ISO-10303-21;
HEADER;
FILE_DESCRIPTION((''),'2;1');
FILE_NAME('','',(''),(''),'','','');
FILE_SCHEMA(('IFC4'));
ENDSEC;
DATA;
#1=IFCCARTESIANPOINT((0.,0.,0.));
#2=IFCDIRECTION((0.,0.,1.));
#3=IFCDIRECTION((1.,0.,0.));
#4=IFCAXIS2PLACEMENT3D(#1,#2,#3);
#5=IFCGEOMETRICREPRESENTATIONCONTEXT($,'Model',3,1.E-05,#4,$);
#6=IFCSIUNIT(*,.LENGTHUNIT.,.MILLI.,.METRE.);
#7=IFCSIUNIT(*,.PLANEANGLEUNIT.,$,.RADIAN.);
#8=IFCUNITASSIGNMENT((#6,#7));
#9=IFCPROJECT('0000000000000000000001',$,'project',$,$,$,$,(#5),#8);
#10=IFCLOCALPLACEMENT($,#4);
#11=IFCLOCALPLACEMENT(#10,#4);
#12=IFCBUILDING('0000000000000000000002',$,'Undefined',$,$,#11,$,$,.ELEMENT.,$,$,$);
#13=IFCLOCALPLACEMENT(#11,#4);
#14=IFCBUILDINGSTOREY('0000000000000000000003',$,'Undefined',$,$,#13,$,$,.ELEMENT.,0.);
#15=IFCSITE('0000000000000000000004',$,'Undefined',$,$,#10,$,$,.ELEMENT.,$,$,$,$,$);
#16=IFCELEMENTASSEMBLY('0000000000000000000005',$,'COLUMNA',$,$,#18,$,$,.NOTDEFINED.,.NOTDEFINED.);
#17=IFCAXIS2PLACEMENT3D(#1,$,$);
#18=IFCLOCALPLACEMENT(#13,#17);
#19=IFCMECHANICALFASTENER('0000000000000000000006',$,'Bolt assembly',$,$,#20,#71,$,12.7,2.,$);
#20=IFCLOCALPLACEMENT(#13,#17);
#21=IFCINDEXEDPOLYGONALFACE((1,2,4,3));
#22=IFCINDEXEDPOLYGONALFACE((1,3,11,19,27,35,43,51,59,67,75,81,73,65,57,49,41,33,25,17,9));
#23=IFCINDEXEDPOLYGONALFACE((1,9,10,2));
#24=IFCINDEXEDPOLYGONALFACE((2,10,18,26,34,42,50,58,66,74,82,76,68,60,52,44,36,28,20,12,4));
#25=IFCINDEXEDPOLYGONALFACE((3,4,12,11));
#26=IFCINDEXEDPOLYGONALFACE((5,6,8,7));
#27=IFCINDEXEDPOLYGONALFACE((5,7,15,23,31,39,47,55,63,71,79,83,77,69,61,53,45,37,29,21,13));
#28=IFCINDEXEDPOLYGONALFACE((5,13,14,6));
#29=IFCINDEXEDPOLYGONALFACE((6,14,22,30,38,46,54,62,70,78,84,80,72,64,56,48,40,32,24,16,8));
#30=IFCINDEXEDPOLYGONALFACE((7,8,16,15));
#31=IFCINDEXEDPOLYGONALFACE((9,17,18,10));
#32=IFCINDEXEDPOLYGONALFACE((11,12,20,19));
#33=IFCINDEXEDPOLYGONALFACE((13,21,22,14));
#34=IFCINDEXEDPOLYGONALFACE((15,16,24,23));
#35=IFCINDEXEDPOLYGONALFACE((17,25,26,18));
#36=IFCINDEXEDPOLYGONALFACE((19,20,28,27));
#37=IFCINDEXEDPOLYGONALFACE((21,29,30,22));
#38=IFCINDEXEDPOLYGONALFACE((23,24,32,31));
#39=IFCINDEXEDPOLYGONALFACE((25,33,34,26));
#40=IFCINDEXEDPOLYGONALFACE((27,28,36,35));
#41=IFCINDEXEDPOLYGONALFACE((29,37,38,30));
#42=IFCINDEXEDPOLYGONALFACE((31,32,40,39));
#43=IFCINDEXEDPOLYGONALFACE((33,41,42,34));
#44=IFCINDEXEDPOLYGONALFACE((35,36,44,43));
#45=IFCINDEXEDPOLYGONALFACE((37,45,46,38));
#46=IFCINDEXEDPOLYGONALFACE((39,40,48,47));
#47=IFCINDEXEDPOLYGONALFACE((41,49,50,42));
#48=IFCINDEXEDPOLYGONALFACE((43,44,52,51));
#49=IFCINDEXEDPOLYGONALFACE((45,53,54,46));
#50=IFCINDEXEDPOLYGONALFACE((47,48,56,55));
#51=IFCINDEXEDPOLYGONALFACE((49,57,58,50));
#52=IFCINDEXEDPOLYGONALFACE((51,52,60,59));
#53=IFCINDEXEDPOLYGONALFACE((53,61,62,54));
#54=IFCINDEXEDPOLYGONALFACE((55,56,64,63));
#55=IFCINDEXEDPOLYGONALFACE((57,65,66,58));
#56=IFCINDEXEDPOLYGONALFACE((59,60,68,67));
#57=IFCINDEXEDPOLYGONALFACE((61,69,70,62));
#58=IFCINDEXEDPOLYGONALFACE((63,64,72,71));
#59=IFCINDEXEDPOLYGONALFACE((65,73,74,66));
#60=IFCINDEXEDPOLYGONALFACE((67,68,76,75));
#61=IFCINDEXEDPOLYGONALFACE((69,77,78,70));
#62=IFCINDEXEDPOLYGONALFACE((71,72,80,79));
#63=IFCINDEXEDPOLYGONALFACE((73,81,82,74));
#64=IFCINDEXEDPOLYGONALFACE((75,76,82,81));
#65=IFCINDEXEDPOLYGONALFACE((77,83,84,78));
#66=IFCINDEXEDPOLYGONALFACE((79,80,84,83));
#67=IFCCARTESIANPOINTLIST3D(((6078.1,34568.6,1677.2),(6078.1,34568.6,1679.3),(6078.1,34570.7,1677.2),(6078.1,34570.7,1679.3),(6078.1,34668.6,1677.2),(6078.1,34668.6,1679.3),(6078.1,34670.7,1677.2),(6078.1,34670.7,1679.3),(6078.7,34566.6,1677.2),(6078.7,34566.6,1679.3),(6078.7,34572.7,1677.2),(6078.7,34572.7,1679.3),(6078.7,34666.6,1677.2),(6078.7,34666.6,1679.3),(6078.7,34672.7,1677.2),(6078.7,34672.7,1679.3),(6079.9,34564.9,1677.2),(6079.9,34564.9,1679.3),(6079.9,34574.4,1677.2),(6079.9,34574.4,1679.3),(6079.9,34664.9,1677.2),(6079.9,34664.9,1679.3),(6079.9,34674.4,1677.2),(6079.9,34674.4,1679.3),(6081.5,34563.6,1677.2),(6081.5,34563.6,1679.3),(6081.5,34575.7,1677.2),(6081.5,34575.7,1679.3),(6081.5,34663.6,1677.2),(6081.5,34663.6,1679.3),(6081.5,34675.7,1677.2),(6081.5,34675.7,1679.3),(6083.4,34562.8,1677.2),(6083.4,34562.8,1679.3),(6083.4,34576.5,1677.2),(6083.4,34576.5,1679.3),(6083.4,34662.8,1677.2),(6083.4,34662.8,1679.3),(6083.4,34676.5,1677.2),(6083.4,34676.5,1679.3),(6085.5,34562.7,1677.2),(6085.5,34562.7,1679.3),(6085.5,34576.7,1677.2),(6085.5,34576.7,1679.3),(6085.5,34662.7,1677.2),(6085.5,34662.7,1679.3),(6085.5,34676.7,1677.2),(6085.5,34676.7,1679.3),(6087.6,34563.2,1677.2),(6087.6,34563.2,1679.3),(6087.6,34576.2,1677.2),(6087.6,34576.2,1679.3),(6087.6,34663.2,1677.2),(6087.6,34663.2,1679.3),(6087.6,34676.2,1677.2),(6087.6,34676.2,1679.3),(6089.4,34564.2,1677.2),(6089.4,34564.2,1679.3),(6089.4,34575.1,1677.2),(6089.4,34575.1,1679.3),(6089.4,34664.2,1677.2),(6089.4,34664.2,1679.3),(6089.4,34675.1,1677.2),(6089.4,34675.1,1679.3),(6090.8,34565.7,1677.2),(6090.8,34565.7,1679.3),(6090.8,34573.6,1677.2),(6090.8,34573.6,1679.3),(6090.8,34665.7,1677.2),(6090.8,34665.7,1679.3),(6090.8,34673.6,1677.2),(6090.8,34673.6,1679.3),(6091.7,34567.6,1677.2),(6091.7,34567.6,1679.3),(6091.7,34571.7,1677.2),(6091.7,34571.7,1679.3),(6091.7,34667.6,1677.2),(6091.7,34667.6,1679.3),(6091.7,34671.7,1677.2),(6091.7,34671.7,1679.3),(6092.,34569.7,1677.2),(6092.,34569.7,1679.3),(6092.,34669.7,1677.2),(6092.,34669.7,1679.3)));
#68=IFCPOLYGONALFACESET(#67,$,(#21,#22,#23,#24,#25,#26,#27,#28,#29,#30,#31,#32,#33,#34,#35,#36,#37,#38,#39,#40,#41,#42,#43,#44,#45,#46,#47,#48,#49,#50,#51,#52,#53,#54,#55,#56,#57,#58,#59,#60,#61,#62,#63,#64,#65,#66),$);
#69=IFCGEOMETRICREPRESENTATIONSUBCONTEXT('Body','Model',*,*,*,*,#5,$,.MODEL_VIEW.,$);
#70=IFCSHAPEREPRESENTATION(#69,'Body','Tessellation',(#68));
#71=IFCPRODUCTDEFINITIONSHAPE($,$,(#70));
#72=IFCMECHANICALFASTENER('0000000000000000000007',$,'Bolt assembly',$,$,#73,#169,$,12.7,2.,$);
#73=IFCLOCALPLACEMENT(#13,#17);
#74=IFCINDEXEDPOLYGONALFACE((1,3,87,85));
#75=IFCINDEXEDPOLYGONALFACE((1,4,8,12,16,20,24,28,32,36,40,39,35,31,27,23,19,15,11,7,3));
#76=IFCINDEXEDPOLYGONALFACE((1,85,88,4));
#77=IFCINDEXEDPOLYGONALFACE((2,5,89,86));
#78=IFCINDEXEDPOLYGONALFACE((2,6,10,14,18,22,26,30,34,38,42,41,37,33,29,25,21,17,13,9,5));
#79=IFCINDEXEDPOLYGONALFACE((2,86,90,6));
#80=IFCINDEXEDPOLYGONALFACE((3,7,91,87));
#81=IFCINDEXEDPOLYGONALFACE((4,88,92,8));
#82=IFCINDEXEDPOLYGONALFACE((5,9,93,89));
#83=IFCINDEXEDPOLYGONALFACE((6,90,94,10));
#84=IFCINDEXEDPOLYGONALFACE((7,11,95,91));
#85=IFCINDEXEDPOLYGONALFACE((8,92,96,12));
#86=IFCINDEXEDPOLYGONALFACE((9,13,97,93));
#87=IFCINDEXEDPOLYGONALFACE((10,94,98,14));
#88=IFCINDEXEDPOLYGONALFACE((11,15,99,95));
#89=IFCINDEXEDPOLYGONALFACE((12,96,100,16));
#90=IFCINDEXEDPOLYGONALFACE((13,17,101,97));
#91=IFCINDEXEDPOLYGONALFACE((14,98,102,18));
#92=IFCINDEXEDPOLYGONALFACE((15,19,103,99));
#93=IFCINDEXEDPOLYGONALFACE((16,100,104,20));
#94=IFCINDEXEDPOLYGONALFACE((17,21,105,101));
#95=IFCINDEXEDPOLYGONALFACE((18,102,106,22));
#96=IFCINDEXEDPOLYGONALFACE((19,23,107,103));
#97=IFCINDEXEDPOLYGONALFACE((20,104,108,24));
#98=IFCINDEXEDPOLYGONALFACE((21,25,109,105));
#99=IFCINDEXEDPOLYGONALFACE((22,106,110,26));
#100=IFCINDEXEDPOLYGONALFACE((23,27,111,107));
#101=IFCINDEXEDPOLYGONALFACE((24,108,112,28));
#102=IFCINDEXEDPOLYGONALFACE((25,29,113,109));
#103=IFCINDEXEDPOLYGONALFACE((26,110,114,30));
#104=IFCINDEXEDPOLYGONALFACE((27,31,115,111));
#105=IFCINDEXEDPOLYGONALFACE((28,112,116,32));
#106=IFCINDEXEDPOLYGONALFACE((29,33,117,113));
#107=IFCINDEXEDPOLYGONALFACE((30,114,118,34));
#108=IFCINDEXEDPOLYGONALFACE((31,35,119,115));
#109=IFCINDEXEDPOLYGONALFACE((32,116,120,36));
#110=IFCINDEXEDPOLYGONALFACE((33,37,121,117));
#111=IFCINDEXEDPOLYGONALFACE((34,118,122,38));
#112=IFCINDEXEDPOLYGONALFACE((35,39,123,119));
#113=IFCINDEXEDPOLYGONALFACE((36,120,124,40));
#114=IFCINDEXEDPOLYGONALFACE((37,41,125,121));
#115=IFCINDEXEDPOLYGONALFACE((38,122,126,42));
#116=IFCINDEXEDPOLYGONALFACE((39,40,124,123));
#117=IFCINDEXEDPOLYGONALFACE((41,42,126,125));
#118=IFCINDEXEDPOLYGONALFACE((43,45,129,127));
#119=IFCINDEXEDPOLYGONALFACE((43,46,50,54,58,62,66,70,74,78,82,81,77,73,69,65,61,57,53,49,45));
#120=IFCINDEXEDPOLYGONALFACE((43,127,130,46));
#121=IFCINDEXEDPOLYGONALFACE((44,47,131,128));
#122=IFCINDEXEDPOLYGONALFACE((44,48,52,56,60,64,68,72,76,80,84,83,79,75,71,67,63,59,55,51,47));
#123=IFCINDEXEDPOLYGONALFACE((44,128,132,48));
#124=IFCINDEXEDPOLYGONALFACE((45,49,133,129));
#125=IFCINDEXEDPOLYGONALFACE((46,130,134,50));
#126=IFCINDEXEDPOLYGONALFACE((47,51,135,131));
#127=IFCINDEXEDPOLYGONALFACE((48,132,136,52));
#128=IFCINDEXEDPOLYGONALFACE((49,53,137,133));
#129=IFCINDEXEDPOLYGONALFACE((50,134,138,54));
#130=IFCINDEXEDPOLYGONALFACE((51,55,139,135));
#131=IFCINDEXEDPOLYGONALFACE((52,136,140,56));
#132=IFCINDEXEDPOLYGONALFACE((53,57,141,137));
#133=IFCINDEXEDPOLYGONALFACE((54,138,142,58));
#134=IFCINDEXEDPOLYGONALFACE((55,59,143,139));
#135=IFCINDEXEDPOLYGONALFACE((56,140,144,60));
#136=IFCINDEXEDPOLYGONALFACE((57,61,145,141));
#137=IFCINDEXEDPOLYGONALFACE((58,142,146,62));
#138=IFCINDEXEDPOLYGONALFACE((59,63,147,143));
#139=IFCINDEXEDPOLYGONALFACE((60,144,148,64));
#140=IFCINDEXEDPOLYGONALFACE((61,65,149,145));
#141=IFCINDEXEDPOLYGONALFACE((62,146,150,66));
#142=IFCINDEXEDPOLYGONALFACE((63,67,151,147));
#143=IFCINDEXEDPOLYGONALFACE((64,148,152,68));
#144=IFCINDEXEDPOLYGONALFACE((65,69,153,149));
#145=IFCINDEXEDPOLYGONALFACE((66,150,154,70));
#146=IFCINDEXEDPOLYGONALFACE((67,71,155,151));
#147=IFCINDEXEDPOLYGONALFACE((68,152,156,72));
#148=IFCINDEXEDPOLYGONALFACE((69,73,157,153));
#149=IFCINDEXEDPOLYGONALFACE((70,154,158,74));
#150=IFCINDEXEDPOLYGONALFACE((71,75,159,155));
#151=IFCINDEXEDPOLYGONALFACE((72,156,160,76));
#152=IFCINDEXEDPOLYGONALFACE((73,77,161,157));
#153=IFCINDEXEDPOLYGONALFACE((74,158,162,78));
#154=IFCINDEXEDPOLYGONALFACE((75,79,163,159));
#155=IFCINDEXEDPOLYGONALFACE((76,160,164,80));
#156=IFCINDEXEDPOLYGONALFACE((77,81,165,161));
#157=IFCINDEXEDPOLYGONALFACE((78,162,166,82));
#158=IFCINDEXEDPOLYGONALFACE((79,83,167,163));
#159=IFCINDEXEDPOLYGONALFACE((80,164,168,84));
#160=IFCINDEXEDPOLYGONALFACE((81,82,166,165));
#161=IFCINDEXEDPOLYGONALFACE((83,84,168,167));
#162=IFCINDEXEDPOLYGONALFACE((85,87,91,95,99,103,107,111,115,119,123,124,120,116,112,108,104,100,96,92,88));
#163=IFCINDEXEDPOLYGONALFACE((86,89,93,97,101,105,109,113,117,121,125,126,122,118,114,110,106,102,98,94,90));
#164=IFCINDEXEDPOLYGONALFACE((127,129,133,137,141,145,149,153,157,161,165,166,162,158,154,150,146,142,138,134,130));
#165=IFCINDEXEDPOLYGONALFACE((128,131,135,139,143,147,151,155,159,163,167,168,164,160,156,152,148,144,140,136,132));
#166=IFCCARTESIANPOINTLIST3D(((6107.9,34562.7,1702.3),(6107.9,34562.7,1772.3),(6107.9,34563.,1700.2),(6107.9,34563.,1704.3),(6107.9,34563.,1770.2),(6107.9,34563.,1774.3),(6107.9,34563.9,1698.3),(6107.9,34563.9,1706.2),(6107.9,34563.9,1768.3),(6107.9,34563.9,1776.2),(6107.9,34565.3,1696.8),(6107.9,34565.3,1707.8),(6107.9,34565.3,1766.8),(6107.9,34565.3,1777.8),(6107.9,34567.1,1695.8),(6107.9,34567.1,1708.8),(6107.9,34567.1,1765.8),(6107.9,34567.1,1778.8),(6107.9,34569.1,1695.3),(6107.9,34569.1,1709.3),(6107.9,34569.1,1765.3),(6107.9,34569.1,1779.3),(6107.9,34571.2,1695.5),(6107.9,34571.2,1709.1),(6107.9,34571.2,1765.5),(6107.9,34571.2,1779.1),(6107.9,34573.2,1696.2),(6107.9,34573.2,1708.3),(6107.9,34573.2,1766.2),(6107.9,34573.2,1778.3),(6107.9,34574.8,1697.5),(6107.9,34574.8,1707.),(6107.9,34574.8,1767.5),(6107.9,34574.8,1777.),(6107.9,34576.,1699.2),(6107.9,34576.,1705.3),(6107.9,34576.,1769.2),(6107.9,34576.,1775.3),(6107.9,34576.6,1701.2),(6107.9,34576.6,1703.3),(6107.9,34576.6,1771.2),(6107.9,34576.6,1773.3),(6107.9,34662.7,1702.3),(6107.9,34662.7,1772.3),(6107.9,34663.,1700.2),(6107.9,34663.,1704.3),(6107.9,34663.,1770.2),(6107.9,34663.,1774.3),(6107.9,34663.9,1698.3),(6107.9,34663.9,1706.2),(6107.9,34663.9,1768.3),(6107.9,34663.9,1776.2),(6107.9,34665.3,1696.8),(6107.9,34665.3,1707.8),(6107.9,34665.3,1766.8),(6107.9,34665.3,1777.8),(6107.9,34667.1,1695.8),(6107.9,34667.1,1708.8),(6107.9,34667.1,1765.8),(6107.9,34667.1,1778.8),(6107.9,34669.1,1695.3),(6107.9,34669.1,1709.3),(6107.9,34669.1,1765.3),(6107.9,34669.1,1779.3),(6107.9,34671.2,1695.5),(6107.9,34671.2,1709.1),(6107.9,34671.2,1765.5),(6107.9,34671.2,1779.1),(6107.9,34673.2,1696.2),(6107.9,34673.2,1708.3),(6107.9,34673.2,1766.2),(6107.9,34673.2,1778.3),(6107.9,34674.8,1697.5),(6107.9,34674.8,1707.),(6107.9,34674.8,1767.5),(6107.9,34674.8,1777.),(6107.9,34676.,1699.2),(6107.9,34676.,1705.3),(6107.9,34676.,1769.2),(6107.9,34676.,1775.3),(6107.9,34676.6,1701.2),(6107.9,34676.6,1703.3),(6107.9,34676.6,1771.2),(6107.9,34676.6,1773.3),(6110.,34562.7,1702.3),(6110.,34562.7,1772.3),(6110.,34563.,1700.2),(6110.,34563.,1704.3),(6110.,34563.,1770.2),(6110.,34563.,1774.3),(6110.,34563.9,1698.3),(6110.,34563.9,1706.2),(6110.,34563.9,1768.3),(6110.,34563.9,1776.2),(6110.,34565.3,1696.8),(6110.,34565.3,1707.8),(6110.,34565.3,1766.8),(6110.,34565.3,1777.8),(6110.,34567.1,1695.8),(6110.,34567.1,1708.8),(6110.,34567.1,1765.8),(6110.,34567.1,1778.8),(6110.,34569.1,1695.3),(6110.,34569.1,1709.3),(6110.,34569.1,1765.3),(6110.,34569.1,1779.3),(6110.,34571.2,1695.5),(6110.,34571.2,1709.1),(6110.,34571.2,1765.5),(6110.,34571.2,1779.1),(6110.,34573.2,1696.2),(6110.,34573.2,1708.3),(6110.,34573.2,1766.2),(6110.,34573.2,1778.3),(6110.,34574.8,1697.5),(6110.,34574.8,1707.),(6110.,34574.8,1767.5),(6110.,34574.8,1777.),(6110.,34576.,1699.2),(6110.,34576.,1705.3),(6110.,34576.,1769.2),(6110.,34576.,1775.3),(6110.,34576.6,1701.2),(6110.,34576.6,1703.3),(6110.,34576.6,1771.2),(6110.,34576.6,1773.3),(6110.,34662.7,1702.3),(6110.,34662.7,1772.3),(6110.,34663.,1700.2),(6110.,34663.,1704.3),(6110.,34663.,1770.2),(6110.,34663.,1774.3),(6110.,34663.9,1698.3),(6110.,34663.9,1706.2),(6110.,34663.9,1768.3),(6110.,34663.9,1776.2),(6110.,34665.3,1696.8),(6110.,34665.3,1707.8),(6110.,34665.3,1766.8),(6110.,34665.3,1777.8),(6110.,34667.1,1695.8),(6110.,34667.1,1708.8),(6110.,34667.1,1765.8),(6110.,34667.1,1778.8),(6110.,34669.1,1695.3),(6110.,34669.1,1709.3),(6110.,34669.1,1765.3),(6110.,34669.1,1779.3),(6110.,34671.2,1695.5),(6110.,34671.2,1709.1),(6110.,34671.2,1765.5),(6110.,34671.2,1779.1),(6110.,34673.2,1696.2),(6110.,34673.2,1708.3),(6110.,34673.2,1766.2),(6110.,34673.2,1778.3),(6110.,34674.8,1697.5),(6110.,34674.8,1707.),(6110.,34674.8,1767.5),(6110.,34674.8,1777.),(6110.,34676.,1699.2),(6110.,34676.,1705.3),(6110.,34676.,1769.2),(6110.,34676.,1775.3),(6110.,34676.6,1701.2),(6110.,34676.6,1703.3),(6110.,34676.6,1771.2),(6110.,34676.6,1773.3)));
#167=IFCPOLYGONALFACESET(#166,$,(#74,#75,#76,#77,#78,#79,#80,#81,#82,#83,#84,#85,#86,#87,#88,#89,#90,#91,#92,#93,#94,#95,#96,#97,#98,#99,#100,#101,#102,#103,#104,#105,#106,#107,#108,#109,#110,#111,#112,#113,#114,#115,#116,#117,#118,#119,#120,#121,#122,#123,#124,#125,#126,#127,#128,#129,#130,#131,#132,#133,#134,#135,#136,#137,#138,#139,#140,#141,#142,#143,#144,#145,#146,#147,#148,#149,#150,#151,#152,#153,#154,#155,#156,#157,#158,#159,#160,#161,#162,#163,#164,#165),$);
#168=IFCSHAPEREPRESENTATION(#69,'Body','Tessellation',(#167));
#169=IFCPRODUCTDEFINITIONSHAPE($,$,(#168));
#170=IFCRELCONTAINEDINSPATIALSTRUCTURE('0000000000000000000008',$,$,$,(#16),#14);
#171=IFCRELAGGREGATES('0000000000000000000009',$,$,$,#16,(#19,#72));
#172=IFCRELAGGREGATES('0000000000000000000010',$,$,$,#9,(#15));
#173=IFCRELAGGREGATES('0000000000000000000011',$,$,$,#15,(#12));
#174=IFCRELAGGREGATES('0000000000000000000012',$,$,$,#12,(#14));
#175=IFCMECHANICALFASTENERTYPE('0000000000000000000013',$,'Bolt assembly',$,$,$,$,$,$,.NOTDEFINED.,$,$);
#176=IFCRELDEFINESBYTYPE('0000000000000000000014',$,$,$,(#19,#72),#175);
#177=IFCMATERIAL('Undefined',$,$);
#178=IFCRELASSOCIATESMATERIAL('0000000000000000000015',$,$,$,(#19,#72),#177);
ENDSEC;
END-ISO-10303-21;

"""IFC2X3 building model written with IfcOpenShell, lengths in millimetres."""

from ifc_helpers import new_model, si_unit, frame, origin_with_axes, origin_2d_with_axis, place, context, subcontext, project, spatial, circle, extrude, source, transform, mapped, material, type_object, element, aggregate, save


model = new_model("IFC2X3")

# Units and contexts
model_context = context("Model", 3, precision=1e-05, world=origin_with_axes())
body_context = subcontext(model_context, "Body", "Model", "MODEL_VIEW")
ifc_project = project(units=[si_unit("LENGTHUNIT", "METRE", prefix="MILLI"), si_unit("PLANEANGLEUNIT", "RADIAN")], contexts=[model_context])

# Site, building, storey
site_placement = place(None, origin_with_axes())
site = spatial("IfcSite", under=ifc_project, at=site_placement, Name="Undefined", CompositionType="ELEMENT")
building_placement = place(site_placement, origin_with_axes())
building = spatial("IfcBuilding", under=site, at=building_placement, Name="Undefined", CompositionType="ELEMENT")
storey_placement = place(building_placement, origin_with_axes())
storey = spatial("IfcBuildingStorey", under=building, at=storey_placement, Name="Undefined", CompositionType="ELEMENT", Elevation=0.0)

# Element assembly
assembly_1_placement = place(storey_placement, origin_with_axes())
assembly_1 = element("IfcElementAssembly", 1, at=assembly_1_placement, inside=storey, Name="COLUMNA", AssemblyPlace="NOTDEFINED", PredefinedType="NOTDEFINED")

# Mechanical fasteners
ifc_material_1 = material(Name="Undefined")
mechanical_fastener_type = type_object("IfcMechanicalFastenerType", Name="Bolt assembly")
shared_shape_1 = source(origin_with_axes(), body_context, "Body", "SweptSolid", [
    extrude(circle(Radius=7.0, at=origin_2d_with_axis()), frame((0.0, -2.0, 0.0), z_axis=(0.0, 1.0, 0.0), x_axis=(1.0, 0.0, 0.0)), (0.0, 0.0, 1.0), 2.1),
])
mechanical_fastener_1_placement = place(assembly_1_placement, frame((6085.0, 34619.7, 1677.3), z_axis=(0.0, 1.0, 0.0), x_axis=(1.0, 0.0, -0.000349)))
mechanical_fastener_1 = element("IfcMechanicalFastener", 2, at=mechanical_fastener_1_placement, type_object=mechanical_fastener_type, material=ifc_material_1, Name="Bolt assembly", NominalDiameter=12.7, NominalLength=2.0, context=body_context, shape_type="MappedRepresentation", body=[
    mapped(shared_shape_1, transform((0.0, 0.0, -50.0))),
    mapped(shared_shape_1, transform((0.0, 0.0, 50.0))),
])
shared_shape_2 = source(origin_with_axes(), body_context, "Body", "SweptSolid", [
    extrude(circle(Radius=7.0, at=origin_2d_with_axis()), frame((0.0, 0.0, 0.0), z_axis=(0.0, 1.0, 0.0), x_axis=(1.0, 0.0, 0.0)), (0.0, 0.0, 1.0), 2.1),
])
mechanical_fastener_2_placement = place(assembly_1_placement, frame((6110.0, 34669.7, 1737.3), z_axis=(0.0, 0.000001, -1.0), x_axis=(0.0, -1.0, 0.0)))
mechanical_fastener_2 = element("IfcMechanicalFastener", 3, at=mechanical_fastener_2_placement, type_object=mechanical_fastener_type, material=ifc_material_1, Name="Bolt assembly", NominalDiameter=12.7, NominalLength=2.0, context=body_context, shape_type="MappedRepresentation", body=[
    mapped(shared_shape_2, transform((0.0, 0.0, -35.0))),
    mapped(shared_shape_2, transform((100.0, 0.0, -35.0))),
    mapped(shared_shape_2, transform((0.0, 0.0, 35.0))),
    mapped(shared_shape_2, transform((100.0, 0.0, 35.0))),
])
aggregate(assembly_1, [mechanical_fastener_1, mechanical_fastener_2])

save(model, "model.ifc")
